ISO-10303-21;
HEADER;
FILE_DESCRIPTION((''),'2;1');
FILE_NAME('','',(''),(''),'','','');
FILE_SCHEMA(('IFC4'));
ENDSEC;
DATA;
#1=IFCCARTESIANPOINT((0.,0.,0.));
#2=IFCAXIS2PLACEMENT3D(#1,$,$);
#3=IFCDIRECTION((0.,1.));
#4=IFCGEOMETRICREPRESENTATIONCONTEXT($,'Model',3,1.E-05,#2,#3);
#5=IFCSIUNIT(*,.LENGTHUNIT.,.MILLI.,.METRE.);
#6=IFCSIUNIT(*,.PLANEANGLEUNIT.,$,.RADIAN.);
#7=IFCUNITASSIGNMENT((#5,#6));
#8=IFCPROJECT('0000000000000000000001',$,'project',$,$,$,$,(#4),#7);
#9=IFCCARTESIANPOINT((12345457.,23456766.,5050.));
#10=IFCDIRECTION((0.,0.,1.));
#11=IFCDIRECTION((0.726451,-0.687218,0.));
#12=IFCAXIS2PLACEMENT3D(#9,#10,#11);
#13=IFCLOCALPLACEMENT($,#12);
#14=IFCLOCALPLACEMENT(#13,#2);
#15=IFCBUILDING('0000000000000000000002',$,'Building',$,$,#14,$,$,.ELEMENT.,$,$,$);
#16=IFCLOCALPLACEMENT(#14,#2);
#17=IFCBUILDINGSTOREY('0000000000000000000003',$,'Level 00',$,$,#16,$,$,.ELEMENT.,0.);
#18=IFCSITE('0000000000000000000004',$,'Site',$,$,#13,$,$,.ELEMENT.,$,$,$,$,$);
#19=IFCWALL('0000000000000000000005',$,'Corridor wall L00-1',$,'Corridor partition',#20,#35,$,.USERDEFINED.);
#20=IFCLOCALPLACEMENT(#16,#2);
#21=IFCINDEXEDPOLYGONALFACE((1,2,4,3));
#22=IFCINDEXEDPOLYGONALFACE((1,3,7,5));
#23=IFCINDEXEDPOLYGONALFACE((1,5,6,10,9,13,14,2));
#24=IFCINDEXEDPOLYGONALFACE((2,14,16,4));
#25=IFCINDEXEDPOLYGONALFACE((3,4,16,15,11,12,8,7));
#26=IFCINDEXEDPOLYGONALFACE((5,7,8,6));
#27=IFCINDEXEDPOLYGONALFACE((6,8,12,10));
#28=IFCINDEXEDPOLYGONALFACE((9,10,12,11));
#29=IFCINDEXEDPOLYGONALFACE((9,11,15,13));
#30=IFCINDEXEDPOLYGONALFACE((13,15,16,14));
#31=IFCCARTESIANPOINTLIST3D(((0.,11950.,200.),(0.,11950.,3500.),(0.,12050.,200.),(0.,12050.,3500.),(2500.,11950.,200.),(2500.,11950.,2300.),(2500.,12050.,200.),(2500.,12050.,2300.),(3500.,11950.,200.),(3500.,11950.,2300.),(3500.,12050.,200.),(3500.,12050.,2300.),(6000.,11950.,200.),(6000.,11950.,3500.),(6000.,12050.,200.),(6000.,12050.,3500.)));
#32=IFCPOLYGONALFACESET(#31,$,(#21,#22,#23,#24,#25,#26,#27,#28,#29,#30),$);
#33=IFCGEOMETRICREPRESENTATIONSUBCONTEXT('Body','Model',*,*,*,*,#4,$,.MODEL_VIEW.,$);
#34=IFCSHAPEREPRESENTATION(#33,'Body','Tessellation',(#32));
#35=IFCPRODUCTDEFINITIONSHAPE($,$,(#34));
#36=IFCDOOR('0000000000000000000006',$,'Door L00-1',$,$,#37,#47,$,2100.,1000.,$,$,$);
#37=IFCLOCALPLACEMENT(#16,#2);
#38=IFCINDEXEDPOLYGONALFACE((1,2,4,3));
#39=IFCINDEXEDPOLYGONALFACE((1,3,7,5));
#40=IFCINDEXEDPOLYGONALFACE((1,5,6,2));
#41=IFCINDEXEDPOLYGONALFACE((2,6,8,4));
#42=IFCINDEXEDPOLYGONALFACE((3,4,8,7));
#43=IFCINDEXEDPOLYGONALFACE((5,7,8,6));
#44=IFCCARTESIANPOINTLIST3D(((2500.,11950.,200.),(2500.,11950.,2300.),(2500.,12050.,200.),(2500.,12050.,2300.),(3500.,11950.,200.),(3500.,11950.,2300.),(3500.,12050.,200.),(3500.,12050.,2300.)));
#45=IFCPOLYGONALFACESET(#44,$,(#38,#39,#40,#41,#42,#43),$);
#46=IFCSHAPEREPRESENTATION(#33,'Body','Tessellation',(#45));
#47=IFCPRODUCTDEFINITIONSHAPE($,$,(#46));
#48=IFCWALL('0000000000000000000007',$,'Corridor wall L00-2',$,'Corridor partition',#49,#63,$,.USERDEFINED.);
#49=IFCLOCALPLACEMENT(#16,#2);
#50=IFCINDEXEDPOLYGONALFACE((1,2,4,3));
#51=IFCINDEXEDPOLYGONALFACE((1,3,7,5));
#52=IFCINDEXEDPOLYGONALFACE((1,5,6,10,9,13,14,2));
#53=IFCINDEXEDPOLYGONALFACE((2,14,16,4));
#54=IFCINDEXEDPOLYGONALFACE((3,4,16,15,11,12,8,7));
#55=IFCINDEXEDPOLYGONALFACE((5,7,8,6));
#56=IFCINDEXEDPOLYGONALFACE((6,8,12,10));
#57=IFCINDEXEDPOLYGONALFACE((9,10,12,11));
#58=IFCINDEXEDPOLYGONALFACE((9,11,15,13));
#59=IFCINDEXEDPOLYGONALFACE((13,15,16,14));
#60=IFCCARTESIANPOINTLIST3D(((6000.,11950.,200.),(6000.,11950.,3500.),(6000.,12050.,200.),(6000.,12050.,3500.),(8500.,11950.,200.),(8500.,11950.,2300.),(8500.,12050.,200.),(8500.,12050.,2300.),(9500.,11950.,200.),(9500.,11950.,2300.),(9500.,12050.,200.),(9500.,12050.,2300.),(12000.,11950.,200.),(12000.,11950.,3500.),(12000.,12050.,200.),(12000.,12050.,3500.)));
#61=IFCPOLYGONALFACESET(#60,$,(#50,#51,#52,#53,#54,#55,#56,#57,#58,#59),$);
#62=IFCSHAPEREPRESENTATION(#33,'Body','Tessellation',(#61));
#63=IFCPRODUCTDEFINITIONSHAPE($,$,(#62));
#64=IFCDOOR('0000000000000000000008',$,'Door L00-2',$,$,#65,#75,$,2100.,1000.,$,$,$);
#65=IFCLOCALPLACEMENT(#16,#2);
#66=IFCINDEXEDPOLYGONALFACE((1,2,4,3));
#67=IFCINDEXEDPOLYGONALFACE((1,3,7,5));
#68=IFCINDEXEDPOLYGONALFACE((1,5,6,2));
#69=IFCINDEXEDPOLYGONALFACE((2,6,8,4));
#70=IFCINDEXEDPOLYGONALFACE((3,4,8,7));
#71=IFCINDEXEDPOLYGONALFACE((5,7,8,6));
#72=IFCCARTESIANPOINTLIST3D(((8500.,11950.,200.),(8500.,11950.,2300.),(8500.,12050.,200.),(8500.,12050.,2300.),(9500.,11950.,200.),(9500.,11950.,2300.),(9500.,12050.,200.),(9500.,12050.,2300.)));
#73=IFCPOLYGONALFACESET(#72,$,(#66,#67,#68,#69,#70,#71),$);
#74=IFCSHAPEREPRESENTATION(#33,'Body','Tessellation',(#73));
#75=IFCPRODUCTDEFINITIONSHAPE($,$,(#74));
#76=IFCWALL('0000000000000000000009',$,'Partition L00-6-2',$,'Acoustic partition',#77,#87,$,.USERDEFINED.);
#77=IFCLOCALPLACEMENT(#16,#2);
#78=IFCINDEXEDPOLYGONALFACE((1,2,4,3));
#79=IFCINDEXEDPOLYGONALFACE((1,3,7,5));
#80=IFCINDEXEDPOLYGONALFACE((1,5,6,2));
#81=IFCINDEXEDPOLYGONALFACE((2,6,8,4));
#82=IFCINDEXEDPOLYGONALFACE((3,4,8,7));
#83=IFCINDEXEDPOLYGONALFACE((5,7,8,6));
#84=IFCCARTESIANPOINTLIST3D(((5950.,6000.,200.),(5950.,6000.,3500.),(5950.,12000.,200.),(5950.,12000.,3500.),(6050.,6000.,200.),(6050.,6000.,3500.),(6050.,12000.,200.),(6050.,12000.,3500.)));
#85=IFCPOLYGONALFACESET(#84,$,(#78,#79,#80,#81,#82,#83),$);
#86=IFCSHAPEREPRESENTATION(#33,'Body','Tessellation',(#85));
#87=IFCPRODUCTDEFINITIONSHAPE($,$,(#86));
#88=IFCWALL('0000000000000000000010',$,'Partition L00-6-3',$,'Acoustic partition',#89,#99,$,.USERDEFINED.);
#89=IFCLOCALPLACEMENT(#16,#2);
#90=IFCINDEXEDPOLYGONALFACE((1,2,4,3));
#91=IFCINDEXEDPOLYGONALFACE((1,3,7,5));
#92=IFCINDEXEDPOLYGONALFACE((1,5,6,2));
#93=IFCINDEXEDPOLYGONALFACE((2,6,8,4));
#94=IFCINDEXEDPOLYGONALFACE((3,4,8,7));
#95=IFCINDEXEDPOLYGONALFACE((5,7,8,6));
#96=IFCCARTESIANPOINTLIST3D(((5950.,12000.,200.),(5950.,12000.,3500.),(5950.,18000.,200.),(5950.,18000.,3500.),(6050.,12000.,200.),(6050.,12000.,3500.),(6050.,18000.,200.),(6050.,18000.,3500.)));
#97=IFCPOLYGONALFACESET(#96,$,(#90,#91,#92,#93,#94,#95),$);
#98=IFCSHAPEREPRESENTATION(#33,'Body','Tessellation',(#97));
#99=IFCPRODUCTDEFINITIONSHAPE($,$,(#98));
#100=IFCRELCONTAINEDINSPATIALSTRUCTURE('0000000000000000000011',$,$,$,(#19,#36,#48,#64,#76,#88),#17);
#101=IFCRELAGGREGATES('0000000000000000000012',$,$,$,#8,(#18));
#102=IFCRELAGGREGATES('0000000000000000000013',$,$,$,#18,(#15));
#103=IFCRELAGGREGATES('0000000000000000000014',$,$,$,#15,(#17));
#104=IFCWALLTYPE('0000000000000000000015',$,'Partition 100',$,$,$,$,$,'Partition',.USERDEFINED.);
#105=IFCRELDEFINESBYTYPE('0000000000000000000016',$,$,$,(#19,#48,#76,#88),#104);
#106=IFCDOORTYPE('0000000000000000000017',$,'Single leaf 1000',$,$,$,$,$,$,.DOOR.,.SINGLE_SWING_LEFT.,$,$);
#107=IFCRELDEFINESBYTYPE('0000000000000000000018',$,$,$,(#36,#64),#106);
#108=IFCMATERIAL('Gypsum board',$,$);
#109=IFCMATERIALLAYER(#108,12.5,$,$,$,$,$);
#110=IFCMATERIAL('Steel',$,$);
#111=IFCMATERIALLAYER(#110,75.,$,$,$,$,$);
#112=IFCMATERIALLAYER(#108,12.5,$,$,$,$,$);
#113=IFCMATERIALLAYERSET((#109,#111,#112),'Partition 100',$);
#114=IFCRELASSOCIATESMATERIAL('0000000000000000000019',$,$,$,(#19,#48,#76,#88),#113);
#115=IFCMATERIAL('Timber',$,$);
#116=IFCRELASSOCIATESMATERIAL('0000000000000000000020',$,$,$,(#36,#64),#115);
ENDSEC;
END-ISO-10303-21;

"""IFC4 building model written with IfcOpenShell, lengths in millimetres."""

from ifc_helpers import new_model, si_unit, direction, frame, origin, place, context, subcontext, project, spatial, rectangle, extrude, source, transform, mapped, material, layer, layer_set, layer_usage, type_object, type_shapes, element, fill, save


model = new_model("IFC4")

# Units and contexts
model_context = context("Model", 3, precision=1e-05, world=origin(), true_north=direction((0.0, 1.0)))
body_context = subcontext(model_context, "Body", "Model", "MODEL_VIEW")
ifc_project = project(units=[si_unit("LENGTHUNIT", "METRE", prefix="MILLI"), si_unit("PLANEANGLEUNIT", "RADIAN")], contexts=[model_context])

# Site, building, storey
site_placement = place(None, frame((12345457.0, 23456766.0, 5050.0), z_axis=(0.0, 0.0, 1.0), x_axis=(0.726451, -0.687218, 0.0)))
site = spatial("IfcSite", under=ifc_project, at=site_placement, Name="Site", CompositionType="ELEMENT")
building_placement = place(site_placement, origin())
building = spatial("IfcBuilding", under=site, at=building_placement, Name="Building", CompositionType="ELEMENT")
storey_placement = place(building_placement, origin())
storey = spatial("IfcBuildingStorey", under=building, at=storey_placement, Name="Level 00", CompositionType="ELEMENT", Elevation=0.0)

# Shared definitions
ifc_material_1 = material(Name="Steel")

# Walls, openings, doors
ifc_material_2 = material(Name="Gypsum board")
ifc_layer_1 = layer(ifc_material_2, 12.5)
ifc_layer_2 = layer(ifc_material_1, 75.0)
ifc_layer_3 = layer(ifc_material_2, 12.5)
ifc_layer_set_1 = layer_set([ifc_layer_1, ifc_layer_2, ifc_layer_3], Name="Partition 100")
ifc_layer_usage_1 = layer_usage(ifc_layer_set_1, "AXIS2", "POSITIVE", 0.0)
wall_type_1 = type_object("IfcWallType", Name="Partition 100", ElementType="Partition", PredefinedType="USERDEFINED")
wall_1_placement = place(storey_placement, frame((0.0, 11950.0, 200.0)))
wall_1 = element("IfcWall", 1, at=wall_1_placement, inside=storey, type_object=wall_type_1, material=ifc_layer_usage_1, Name="Corridor wall L00-1", ObjectType="Corridor partition", PredefinedType="USERDEFINED", context=body_context, shape_type="SweptSolid", body=[
    extrude(rectangle(XDim=6000.0, YDim=100.0), frame((3000.0, 50.0, 0.0)), (0.0, 0.0, 1.0), 3300.0),
])
opening_1_placement = place(wall_1_placement, frame((2500.0, -50.0, 0.0)))
opening_1 = element("IfcOpeningElement", 2, at=opening_1_placement, cuts=wall_1, PredefinedType="OPENING", context=body_context, shape_type="SweptSolid", body=[
    extrude(rectangle(XDim=1000.0, YDim=200.0), frame((500.0, 100.0, 0.0)), (0.0, 0.0, 1.0), 2100.0),
])
ifc_material_3 = material(Name="Timber")
door_type = type_object("IfcDoorType", Name="Single leaf 1000", OperationType="SINGLE_SWING_LEFT", PredefinedType="DOOR")
shared_shape = source(origin(), body_context, "Body", "SweptSolid", [
    extrude(rectangle(XDim=1000.0, YDim=100.0), frame((500.0, 50.0, 0.0)), (0.0, 0.0, 1.0), 2100.0),
])
type_shapes(door_type, [shared_shape])
door_1_placement = place(storey_placement, frame((2500.0, 11950.0, 200.0)))
door_1 = element("IfcDoor", 3, at=door_1_placement, inside=storey, type_object=door_type, material=ifc_material_3, Name="Door L00-1", OverallHeight=2100.0, OverallWidth=1000.0, context=body_context, shape_type="MappedRepresentation", body=[
    mapped(shared_shape, transform((0.0, 0.0, 0.0))),
])
fill(opening_1, door_1)
wall_2_placement = place(storey_placement, frame((6000.0, 11950.0, 200.0)))
wall_2 = element("IfcWall", 4, at=wall_2_placement, inside=storey, type_object=wall_type_1, material=ifc_layer_usage_1, Name="Corridor wall L00-2", ObjectType="Corridor partition", PredefinedType="USERDEFINED", context=body_context, shape_type="SweptSolid", body=[
    extrude(rectangle(XDim=6000.0, YDim=100.0), frame((3000.0, 50.0, 0.0)), (0.0, 0.0, 1.0), 3300.0),
])
opening_2_placement = place(wall_2_placement, frame((2500.0, -50.0, 0.0)))
opening_2 = element("IfcOpeningElement", 5, at=opening_2_placement, cuts=wall_2, PredefinedType="OPENING", context=body_context, shape_type="SweptSolid", body=[
    extrude(rectangle(XDim=1000.0, YDim=200.0), frame((500.0, 100.0, 0.0)), (0.0, 0.0, 1.0), 2100.0),
])
door_2_placement = place(storey_placement, frame((8500.0, 11950.0, 200.0)))
door_2 = element("IfcDoor", 6, at=door_2_placement, inside=storey, type_object=door_type, material=ifc_material_3, Name="Door L00-2", OverallHeight=2100.0, OverallWidth=1000.0, context=body_context, shape_type="MappedRepresentation", body=[
    mapped(shared_shape, transform((0.0, 0.0, 0.0))),
])
fill(opening_2, door_2)

# Walls
for number, where, name in (
    (7, (5950.0, 6000.0, 200.0), "Partition L00-6-2"),
    (8, (5950.0, 12000.0, 200.0), "Partition L00-6-3"),
):
    element("IfcWall", number, at=place(storey_placement, frame(where)), inside=storey, type_object=wall_type_1, material=ifc_layer_usage_1, Name=name, ObjectType="Acoustic partition", PredefinedType="USERDEFINED", context=body_context, shape_type="SweptSolid", body=[
        extrude(rectangle(XDim=100.0, YDim=6000.0), frame((50.0, 3000.0, 0.0)), (0.0, 0.0, 1.0), 3300.0),
    ])

save(model, "model.ifc")
